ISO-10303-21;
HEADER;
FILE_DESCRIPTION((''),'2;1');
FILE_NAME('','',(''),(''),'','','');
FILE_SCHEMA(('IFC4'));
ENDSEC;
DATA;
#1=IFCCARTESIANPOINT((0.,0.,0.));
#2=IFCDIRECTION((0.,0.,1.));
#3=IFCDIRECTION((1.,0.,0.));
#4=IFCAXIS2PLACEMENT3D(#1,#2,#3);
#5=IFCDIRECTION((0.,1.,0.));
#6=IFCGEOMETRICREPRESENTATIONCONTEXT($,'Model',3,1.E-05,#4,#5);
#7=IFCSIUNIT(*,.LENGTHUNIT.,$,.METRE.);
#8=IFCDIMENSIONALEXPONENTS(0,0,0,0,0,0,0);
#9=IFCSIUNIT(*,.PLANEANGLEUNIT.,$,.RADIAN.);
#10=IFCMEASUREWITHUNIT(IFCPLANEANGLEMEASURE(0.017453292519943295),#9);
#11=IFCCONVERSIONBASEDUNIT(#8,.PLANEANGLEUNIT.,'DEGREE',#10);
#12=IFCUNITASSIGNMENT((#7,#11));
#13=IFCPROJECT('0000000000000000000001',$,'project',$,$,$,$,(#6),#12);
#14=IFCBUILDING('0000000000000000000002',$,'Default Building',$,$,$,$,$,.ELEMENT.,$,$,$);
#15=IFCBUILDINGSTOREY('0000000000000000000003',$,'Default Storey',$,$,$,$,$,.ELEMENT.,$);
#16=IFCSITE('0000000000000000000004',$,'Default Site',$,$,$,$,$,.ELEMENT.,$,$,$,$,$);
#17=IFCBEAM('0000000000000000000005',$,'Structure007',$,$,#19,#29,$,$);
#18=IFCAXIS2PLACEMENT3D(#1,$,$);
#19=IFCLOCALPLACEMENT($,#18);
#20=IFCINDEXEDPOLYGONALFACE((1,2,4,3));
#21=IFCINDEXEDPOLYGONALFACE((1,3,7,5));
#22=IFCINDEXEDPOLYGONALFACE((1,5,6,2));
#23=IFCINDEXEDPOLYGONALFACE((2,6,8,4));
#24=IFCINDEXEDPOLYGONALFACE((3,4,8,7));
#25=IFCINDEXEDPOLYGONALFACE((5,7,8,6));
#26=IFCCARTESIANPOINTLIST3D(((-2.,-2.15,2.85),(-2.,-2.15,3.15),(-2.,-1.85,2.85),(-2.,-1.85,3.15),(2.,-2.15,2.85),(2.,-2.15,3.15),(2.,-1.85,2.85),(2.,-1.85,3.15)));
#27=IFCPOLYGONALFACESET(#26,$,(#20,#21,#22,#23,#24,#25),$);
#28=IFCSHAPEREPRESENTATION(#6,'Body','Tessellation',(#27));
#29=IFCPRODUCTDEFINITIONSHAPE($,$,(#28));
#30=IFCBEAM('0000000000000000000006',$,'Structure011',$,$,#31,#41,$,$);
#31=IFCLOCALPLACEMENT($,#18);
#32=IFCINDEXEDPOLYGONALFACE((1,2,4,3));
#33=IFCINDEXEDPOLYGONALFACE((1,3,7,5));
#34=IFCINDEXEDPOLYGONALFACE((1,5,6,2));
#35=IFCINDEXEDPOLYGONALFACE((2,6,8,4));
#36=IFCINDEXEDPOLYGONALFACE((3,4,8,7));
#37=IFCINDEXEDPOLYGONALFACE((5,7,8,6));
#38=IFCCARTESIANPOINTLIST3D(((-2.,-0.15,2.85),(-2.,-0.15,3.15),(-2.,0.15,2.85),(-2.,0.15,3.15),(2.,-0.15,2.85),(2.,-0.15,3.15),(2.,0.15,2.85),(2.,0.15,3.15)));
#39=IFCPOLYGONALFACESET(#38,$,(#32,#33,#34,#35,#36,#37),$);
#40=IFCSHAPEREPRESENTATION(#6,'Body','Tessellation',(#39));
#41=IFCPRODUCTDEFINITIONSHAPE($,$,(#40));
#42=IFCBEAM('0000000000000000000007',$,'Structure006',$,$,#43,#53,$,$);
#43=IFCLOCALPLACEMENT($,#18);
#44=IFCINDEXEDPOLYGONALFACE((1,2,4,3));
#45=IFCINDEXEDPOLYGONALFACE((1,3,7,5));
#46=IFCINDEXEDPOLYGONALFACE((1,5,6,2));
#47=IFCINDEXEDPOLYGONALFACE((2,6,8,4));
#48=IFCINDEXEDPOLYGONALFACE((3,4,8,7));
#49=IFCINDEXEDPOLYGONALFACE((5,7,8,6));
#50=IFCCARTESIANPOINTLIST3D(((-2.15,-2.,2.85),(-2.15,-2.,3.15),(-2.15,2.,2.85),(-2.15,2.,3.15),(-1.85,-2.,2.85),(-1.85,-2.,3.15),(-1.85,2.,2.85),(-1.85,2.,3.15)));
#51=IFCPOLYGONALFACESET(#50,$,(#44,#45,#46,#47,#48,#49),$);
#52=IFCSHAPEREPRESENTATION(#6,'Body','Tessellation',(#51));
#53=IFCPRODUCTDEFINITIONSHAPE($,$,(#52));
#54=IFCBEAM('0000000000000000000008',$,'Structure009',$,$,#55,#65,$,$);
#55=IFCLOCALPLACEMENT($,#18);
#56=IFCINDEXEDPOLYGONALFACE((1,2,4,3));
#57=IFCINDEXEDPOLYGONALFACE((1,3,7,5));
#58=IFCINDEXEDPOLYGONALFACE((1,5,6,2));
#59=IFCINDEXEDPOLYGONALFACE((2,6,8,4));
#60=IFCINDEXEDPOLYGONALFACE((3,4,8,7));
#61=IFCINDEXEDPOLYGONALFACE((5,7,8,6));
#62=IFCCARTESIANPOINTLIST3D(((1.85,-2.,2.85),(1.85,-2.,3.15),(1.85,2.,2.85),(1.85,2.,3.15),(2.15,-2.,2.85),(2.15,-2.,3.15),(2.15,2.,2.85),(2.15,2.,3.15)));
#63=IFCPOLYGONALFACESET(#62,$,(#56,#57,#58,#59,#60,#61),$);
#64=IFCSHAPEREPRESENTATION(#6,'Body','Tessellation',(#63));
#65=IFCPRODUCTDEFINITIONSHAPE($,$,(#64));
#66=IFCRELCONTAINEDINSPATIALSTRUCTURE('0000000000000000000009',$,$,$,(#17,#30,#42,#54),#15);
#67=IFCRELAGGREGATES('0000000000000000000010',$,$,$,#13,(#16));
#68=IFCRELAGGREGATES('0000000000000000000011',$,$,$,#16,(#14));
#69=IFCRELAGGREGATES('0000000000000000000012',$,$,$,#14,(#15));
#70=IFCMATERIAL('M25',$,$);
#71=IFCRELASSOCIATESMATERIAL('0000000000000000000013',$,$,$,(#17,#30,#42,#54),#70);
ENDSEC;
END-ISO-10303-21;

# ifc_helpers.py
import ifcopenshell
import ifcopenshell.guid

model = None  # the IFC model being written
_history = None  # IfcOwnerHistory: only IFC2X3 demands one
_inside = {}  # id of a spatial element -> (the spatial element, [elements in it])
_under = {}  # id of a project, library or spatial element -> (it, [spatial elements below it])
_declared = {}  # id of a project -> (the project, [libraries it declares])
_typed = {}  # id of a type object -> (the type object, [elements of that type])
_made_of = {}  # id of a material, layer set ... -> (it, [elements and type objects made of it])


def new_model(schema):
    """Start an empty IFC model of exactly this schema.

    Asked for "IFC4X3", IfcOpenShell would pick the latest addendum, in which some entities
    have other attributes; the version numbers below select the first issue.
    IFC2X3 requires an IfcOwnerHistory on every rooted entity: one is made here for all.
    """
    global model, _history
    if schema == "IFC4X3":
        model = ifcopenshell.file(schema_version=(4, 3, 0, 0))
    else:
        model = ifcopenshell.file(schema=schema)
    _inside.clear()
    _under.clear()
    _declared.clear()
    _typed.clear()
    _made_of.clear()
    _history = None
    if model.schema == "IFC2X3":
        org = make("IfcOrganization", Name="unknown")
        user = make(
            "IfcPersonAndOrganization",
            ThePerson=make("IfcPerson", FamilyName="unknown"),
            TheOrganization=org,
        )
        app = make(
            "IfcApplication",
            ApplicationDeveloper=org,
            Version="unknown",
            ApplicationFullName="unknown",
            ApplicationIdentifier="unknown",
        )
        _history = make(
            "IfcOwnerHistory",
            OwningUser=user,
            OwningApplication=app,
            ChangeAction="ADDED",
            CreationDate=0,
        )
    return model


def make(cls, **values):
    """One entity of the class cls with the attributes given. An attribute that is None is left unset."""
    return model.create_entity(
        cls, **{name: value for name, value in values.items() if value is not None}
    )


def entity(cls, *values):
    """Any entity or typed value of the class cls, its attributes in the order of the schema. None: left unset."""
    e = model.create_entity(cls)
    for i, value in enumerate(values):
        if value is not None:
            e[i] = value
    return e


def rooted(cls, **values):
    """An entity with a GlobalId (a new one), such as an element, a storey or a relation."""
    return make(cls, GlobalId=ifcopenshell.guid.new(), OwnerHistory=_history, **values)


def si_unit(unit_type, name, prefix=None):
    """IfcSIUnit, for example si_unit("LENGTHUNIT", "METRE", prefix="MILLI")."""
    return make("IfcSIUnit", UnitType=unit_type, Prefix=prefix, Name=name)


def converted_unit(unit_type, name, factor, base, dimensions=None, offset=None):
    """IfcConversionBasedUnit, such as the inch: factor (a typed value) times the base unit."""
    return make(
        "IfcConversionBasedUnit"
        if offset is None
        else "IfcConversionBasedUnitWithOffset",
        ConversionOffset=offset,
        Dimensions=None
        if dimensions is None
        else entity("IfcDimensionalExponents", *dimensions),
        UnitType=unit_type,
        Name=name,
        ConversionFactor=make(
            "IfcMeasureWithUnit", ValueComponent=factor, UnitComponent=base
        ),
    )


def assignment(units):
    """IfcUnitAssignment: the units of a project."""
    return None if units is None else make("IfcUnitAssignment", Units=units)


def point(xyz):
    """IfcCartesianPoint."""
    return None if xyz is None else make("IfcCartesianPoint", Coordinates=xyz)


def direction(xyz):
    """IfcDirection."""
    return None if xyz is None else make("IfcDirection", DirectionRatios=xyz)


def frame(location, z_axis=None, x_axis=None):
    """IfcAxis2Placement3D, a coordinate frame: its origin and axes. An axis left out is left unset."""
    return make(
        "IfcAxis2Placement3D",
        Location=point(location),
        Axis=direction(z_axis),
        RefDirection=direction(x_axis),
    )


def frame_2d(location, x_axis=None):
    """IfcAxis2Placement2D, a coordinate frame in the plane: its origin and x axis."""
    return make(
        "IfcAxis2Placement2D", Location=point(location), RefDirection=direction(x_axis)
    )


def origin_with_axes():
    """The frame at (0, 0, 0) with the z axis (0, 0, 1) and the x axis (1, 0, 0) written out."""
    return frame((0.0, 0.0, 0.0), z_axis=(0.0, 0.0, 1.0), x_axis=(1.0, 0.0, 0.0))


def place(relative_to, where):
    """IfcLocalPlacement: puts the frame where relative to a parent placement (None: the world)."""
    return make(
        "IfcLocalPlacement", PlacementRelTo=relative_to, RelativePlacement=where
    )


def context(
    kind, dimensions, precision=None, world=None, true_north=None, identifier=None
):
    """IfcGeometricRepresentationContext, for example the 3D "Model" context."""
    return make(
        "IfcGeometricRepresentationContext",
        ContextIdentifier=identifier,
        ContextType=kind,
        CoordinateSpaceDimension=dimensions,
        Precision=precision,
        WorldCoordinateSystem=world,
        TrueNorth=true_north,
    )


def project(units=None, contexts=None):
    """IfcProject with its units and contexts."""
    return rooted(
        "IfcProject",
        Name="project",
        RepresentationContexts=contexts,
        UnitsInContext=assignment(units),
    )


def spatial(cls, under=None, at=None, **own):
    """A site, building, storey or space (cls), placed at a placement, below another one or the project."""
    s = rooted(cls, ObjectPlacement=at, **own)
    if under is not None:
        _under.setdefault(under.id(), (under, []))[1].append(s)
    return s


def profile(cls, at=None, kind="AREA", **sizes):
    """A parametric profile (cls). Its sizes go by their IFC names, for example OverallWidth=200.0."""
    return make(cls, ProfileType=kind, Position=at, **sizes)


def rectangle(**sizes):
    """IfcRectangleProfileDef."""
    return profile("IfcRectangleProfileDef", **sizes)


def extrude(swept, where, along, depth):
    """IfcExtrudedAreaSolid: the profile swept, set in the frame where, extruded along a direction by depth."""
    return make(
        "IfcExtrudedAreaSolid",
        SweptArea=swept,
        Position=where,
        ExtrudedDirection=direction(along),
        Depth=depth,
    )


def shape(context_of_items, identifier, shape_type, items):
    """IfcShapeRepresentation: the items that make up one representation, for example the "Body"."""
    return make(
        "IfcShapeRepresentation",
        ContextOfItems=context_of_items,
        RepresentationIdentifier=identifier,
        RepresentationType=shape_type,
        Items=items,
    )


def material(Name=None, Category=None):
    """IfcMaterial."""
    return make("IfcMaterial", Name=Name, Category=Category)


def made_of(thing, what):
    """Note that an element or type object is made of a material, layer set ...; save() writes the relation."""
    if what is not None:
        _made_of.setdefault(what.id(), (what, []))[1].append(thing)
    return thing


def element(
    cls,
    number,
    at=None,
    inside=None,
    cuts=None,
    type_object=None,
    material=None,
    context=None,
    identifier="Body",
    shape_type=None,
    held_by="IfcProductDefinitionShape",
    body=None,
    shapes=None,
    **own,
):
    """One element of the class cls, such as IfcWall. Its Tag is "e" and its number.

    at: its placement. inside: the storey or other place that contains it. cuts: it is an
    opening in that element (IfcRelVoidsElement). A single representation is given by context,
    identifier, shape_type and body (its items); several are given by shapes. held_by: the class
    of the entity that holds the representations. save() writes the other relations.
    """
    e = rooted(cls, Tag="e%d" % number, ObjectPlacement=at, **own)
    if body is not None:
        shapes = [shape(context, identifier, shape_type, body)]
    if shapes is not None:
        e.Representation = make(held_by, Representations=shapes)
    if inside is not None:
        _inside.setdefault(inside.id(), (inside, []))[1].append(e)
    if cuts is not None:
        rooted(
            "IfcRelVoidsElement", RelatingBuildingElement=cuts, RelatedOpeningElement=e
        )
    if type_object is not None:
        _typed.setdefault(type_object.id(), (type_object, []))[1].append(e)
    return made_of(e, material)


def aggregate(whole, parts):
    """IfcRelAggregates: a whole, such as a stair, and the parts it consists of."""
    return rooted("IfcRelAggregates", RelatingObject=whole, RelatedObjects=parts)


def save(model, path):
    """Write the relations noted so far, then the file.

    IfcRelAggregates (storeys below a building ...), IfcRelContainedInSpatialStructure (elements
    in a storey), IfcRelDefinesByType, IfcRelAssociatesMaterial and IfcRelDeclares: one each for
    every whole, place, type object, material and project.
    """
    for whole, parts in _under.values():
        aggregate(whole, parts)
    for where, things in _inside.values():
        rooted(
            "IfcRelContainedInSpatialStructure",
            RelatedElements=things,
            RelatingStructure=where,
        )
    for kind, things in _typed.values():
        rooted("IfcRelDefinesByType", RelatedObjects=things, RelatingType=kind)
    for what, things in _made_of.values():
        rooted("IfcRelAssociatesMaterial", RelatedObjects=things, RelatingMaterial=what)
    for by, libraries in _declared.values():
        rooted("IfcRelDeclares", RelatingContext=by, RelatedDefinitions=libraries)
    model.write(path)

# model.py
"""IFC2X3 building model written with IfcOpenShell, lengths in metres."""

from ifc_helpers import new_model, entity, si_unit, converted_unit, direction, frame, frame_2d, origin_with_axes, place, context, project, spatial, rectangle, extrude, material, element, save


model = new_model("IFC2X3")

# Units and contexts
model_context = context("Model", 3, precision=1e-05, world=origin_with_axes(), true_north=direction((0.0, 1.0, 0.0)))
ifc_project = project(units=[si_unit("LENGTHUNIT", "METRE"), converted_unit("PLANEANGLEUNIT", "DEGREE", entity("IfcPlaneAngleMeasure", 0.017453292519943295), si_unit("PLANEANGLEUNIT", "RADIAN"), dimensions=[0, 0, 0, 0, 0, 0, 0])], contexts=[model_context])

# Site, building, storey
site = spatial("IfcSite", under=ifc_project, Name="Default Site", CompositionType="ELEMENT")
building = spatial("IfcBuilding", under=site, Name="Default Building", CompositionType="ELEMENT")
storey = spatial("IfcBuildingStorey", under=building, Name="Default Storey", CompositionType="ELEMENT")

# Shared definitions
ifc_material = material(Name="M25")
placement = place(None, origin_with_axes())

# Beams
element("IfcBeam", 1, at=placement, inside=storey, material=ifc_material, Name="Structure007", context=model_context, shape_type="SweptSolid", body=[
    extrude(rectangle(XDim=0.3, YDim=0.3, at=frame_2d((0.0, 0.0), x_axis=(0.0, 1.0, 0.0))), frame((2.0, -2.0, 3.0), z_axis=(-1.0, 0.0, 0.0), x_axis=(0.0, 0.0, -1.0)), (0.0, 0.0, 1.0), 4.0),
])
element("IfcBeam", 2, at=placement, inside=storey, material=ifc_material, Name="Structure011", context=model_context, shape_type="SweptSolid", body=[
    extrude(rectangle(XDim=0.3, YDim=0.3, at=frame_2d((0.0, 0.0), x_axis=(0.0, 1.0, 0.0))), frame((2.0, 0.0, 3.0), z_axis=(-1.0, 0.0, 0.0), x_axis=(0.0, 0.0, -1.0)), (0.0, 0.0, 1.0), 4.0),
])
element("IfcBeam", 3, at=placement, inside=storey, material=ifc_material, Name="Structure006", context=model_context, shape_type="SweptSolid", body=[
    extrude(rectangle(XDim=0.3, YDim=0.3, at=frame_2d((0.0, 0.0), x_axis=(0.0, 1.0, 0.0))), frame((-2.0, 2.0, 3.0), z_axis=(0.0, -1.0, 0.0), x_axis=(0.0, 0.0, -1.0)), (0.0, 0.0, 1.0), 4.0),
])
element("IfcBeam", 4, at=placement, inside=storey, material=ifc_material, Name="Structure009", context=model_context, shape_type="SweptSolid", body=[
    extrude(rectangle(XDim=0.3, YDim=0.3, at=frame_2d((0.0, 0.0), x_axis=(0.0, 1.0, 0.0))), frame((2.0, 2.0, 3.0), z_axis=(0.0, -1.0, 0.0), x_axis=(0.0, 0.0, -1.0)), (0.0, 0.0, 1.0), 4.0),
])

save(model, "model.ifc")
